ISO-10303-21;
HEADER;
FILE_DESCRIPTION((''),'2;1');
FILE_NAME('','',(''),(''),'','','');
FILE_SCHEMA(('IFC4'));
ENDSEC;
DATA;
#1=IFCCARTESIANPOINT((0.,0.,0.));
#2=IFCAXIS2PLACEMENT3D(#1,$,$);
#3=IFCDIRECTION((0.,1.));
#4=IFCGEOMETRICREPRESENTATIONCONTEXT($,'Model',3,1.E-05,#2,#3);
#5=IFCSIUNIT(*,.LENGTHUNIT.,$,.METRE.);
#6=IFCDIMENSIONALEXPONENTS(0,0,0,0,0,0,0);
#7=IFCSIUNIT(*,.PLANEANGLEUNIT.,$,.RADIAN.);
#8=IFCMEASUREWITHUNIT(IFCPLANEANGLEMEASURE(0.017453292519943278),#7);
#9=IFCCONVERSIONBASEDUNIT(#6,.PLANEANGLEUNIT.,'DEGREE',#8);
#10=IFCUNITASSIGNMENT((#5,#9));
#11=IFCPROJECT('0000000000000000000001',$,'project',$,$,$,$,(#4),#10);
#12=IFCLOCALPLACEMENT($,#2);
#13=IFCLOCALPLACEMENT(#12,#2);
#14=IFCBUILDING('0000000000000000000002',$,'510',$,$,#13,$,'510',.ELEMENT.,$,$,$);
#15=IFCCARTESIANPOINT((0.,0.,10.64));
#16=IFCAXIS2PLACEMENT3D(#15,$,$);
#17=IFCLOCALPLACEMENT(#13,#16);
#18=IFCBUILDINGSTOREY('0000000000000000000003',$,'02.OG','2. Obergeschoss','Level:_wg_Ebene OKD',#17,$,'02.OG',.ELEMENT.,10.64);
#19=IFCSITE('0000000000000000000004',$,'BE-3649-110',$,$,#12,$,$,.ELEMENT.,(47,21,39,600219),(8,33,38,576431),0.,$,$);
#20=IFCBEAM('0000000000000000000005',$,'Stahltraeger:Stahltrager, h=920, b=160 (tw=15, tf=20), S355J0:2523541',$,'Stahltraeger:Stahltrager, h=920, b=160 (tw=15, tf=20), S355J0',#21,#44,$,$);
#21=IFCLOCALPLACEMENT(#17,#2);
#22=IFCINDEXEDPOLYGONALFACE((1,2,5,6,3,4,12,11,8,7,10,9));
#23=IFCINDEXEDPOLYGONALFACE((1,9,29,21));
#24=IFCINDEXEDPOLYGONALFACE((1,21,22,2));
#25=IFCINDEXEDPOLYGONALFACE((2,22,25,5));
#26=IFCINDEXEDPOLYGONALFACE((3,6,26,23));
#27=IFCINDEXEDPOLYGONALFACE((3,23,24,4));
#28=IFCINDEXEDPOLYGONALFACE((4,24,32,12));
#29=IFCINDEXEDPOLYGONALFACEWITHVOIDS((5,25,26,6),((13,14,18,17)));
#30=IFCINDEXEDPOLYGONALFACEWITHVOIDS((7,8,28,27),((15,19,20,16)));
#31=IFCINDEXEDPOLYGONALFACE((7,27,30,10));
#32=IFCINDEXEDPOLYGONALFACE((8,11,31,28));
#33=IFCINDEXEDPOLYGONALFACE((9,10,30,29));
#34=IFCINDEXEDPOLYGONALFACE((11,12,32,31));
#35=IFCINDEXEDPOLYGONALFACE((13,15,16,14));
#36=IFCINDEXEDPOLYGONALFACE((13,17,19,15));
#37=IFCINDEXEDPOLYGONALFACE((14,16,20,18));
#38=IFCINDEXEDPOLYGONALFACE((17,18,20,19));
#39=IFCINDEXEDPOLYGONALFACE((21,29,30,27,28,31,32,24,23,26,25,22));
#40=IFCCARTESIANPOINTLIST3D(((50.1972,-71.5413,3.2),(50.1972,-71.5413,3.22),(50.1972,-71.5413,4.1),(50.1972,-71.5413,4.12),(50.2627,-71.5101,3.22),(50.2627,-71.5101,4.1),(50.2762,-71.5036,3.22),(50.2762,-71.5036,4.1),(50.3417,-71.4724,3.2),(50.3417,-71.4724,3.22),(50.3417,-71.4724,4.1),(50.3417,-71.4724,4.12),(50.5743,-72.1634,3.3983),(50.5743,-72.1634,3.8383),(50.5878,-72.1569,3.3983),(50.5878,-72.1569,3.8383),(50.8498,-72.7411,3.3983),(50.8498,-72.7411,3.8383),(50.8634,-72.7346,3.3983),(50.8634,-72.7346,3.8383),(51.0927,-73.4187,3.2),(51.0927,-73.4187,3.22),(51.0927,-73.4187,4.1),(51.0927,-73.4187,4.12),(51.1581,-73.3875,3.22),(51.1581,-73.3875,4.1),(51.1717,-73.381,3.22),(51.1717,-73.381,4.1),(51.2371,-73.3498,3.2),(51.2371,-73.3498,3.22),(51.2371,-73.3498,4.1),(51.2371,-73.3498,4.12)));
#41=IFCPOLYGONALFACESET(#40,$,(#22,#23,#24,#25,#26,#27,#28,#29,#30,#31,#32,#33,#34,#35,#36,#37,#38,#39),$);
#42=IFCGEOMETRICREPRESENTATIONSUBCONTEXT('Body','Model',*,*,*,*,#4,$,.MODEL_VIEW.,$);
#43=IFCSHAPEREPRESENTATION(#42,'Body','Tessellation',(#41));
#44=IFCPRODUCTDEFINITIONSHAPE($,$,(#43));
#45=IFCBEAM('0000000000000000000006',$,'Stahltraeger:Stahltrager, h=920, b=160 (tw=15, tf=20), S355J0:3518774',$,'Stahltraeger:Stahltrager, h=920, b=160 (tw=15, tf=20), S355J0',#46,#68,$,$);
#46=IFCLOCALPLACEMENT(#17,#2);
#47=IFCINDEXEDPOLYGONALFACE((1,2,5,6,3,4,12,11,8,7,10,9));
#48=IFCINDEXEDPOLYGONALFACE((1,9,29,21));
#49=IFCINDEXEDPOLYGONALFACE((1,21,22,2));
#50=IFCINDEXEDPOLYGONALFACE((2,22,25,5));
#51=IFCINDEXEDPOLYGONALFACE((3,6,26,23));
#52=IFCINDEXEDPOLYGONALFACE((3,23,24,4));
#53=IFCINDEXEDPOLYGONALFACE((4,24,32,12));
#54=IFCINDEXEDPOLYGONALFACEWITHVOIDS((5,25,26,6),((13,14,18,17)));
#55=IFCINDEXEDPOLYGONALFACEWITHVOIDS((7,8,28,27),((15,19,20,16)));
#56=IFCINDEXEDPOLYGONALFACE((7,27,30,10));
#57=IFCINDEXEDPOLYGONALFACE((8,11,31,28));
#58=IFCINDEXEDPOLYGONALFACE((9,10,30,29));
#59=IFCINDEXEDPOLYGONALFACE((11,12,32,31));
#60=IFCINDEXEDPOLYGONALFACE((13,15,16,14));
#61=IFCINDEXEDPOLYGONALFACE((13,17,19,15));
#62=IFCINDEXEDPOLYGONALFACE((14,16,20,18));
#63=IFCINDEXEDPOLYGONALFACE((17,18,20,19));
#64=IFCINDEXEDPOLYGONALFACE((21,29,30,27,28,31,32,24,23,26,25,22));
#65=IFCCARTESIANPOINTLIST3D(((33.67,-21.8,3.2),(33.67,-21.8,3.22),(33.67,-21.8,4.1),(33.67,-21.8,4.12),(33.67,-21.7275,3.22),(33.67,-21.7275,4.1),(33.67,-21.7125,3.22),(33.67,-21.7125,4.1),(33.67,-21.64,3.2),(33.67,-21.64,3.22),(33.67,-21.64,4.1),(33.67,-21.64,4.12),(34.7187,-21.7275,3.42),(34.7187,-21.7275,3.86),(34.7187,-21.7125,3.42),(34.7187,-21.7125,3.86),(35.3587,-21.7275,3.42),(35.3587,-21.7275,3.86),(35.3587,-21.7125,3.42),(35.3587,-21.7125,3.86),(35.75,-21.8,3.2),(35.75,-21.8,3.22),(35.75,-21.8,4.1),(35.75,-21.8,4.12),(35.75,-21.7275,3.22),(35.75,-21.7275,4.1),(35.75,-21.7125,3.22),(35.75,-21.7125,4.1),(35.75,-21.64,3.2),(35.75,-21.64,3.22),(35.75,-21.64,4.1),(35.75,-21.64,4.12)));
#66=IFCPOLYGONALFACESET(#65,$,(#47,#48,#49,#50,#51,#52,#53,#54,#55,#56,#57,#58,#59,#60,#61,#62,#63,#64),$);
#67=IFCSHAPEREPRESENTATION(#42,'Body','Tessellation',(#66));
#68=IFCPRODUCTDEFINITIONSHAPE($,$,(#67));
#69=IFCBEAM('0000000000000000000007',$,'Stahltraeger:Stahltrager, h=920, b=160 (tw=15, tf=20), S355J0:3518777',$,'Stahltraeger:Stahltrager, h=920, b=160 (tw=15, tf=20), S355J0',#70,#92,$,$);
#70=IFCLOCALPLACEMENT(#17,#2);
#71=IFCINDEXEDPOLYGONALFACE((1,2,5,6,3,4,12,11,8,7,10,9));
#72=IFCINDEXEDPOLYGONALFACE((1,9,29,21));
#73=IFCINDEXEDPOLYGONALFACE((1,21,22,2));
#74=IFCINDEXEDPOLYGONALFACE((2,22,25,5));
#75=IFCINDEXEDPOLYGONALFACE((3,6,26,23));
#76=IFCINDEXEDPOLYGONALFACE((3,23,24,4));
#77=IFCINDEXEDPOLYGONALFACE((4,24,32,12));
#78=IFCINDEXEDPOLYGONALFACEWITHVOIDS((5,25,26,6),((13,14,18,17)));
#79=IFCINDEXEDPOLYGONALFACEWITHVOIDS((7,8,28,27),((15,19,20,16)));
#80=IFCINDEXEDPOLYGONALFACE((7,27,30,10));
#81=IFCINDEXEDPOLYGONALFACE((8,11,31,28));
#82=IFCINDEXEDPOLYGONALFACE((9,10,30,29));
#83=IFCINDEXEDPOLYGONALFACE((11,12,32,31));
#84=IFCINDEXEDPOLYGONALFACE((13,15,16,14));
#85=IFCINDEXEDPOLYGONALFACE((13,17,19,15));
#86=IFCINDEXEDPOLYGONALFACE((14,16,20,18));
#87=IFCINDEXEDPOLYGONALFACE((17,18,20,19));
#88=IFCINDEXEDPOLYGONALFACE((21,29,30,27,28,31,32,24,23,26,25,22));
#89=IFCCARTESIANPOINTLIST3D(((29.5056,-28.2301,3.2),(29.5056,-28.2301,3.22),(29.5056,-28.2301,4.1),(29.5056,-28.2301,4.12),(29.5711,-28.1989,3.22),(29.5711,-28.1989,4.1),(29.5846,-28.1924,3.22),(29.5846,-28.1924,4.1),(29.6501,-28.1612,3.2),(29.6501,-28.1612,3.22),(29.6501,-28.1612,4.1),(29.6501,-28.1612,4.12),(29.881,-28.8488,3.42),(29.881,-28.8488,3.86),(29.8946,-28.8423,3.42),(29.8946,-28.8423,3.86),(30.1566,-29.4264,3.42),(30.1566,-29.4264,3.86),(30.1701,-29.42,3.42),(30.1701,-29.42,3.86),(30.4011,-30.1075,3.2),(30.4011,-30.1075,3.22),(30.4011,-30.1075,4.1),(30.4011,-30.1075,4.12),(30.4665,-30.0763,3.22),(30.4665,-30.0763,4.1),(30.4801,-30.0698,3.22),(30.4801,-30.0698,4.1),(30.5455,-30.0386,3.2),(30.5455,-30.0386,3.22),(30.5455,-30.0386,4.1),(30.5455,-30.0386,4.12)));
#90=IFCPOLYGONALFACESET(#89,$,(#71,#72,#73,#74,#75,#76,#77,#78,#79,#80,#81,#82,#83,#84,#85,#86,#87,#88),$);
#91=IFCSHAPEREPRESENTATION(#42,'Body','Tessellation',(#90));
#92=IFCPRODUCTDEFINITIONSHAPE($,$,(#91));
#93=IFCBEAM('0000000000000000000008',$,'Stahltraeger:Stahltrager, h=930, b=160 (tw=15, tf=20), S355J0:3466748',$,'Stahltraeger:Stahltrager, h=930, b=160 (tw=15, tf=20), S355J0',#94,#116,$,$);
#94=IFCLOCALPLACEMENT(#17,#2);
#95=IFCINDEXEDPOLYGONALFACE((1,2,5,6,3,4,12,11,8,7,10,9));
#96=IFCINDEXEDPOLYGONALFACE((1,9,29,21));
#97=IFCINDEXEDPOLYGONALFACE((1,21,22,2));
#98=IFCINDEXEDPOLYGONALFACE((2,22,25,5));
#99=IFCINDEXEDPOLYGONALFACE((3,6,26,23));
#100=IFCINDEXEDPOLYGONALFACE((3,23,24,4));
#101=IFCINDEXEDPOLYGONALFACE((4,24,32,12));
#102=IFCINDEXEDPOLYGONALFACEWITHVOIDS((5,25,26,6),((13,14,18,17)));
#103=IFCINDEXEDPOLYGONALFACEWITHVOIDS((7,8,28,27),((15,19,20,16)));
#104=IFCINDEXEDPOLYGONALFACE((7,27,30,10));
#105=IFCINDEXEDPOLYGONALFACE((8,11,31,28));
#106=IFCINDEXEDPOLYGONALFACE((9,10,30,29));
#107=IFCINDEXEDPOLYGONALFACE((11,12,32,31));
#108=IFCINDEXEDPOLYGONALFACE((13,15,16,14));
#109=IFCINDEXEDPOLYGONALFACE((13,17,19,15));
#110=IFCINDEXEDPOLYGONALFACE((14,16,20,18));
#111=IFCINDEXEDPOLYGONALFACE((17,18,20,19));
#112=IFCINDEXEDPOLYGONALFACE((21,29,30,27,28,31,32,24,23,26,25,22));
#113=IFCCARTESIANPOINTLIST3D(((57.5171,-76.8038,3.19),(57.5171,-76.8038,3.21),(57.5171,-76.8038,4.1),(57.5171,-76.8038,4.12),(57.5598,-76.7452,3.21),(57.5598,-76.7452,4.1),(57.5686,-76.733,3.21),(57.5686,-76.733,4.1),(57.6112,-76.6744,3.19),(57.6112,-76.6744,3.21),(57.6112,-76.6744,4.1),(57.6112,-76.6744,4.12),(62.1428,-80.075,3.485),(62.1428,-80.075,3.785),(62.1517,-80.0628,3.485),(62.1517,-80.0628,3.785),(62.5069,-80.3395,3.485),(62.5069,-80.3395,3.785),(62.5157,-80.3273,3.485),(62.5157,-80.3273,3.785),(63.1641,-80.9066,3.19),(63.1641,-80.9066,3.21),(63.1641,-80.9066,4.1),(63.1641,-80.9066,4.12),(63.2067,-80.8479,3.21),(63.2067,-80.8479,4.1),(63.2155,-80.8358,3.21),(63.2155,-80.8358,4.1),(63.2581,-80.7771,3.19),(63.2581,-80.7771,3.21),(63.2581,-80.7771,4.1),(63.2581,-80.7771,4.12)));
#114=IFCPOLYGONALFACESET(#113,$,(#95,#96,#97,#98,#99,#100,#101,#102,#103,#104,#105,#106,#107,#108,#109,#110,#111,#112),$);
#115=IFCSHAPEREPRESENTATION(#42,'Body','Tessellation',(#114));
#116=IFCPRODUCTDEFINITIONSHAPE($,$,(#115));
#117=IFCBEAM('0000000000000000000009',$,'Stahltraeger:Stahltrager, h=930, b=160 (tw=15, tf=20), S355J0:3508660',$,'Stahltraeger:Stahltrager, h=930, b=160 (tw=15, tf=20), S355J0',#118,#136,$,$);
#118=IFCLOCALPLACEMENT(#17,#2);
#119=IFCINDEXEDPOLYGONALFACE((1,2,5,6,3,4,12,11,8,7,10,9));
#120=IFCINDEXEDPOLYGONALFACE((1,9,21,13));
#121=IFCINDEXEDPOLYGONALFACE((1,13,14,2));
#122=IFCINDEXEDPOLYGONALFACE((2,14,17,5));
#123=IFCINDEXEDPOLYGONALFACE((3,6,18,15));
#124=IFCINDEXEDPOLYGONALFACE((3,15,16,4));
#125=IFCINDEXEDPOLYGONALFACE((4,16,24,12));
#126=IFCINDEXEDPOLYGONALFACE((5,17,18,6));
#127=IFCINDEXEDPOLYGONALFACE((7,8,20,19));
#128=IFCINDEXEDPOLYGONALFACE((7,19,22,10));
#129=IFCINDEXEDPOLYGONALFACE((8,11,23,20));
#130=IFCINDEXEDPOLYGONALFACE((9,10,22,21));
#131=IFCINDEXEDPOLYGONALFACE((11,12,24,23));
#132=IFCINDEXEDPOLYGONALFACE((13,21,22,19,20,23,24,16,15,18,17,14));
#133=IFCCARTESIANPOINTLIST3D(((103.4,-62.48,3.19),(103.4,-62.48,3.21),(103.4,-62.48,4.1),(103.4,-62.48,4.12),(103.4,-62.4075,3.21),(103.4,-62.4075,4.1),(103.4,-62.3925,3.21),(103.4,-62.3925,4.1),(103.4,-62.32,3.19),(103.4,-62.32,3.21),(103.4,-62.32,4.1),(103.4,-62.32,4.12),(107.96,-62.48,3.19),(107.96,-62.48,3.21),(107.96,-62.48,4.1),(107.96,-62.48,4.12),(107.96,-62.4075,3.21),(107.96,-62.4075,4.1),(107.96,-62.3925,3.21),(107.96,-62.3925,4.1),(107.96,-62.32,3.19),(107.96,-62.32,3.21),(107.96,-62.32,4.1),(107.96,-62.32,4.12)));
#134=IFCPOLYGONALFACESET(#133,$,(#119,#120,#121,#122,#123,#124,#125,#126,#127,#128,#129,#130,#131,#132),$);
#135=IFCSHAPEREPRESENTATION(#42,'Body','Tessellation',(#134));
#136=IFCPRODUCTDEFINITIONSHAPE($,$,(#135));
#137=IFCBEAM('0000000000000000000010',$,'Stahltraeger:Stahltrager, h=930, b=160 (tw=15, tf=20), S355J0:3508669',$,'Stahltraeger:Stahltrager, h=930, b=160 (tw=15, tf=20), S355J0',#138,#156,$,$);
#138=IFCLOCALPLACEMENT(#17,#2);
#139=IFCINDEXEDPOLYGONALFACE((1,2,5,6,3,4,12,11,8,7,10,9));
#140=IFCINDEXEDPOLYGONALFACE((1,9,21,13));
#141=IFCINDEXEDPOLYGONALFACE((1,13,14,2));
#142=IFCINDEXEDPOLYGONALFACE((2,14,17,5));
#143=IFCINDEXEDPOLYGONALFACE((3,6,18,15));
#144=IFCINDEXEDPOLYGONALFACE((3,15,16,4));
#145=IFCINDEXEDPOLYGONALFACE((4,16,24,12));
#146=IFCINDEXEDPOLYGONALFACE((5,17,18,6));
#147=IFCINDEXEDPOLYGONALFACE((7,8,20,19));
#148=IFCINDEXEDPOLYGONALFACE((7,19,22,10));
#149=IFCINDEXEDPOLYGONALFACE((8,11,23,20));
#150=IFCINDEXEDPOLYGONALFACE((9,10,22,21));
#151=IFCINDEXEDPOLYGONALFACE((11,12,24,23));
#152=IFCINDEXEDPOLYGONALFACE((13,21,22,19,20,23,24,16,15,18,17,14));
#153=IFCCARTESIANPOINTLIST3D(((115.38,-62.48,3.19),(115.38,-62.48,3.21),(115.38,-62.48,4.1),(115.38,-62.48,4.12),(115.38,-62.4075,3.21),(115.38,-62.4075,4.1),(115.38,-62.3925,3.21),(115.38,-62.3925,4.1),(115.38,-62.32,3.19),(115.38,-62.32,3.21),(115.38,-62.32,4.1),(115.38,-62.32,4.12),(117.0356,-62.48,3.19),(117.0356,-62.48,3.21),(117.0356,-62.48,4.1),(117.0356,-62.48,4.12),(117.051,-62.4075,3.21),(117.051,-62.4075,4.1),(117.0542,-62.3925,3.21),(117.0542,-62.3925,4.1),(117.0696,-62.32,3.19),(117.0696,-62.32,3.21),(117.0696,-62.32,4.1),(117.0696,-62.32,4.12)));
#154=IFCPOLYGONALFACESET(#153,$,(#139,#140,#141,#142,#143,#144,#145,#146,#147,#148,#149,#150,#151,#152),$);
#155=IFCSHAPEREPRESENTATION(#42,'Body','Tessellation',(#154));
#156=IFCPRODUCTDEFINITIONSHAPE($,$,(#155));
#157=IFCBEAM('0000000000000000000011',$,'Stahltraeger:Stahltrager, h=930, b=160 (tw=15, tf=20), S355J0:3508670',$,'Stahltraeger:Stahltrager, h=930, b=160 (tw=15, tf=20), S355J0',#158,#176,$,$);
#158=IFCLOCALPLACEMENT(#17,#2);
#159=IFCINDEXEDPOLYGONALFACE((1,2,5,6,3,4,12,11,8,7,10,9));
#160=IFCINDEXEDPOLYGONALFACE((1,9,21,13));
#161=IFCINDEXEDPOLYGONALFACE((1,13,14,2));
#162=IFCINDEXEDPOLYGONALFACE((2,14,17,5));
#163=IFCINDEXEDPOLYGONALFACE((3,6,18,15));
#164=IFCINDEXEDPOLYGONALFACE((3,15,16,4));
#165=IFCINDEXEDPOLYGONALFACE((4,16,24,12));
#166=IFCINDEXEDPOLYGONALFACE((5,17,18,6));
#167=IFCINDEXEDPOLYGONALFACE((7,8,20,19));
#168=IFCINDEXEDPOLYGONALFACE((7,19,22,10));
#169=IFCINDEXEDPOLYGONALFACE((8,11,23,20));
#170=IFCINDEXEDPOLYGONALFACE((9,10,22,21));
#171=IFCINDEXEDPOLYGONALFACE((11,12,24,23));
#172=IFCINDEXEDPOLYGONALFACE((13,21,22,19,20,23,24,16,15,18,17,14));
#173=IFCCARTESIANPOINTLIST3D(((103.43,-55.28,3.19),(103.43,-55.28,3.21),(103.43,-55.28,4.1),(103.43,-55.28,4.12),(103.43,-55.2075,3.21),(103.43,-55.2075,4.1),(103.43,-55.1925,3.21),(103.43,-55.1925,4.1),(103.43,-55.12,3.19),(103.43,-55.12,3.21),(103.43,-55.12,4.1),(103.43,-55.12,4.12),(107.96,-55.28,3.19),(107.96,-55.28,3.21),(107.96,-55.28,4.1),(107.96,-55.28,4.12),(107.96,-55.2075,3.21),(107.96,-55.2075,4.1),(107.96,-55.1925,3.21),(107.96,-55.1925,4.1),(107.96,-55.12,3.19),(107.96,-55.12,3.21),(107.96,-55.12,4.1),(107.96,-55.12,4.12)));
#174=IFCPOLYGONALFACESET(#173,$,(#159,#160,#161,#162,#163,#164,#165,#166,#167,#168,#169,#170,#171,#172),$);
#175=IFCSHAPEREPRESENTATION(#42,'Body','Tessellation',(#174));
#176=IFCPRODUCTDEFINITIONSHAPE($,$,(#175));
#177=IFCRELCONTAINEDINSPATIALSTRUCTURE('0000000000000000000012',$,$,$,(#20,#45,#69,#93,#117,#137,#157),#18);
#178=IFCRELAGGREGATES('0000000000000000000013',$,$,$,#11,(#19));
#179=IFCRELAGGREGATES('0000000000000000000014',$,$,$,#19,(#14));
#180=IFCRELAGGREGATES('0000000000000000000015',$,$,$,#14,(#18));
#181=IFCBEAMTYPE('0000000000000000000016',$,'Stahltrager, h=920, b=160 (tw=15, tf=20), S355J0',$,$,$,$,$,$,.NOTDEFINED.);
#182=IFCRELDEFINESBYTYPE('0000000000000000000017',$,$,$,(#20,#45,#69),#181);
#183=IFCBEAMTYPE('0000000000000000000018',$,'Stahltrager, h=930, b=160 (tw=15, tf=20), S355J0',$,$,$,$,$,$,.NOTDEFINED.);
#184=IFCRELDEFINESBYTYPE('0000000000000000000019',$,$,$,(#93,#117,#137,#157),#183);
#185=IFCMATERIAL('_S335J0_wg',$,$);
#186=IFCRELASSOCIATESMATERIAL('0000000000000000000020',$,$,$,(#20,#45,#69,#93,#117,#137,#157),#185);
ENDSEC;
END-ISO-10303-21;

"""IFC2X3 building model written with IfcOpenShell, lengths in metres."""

from ifc_helpers import new_model, entity, si_unit, converted_unit, direction, frame, frame_2d, origin, place, context, subcontext, project, spatial, polyline, rectangle, i_section, outline, extrude, boolean, clip, halfspace, material, type_object, element, save


model = new_model("IFC2X3")

# Units and contexts
model_context = context("Model", 3, precision=1e-05, world=origin(), true_north=direction((0.0, 1.0)))
body_context = subcontext(model_context, "Body", "Model", "MODEL_VIEW")
ifc_project = project(units=[si_unit("LENGTHUNIT", "METRE"), converted_unit("PLANEANGLEUNIT", "DEGREE", entity("IfcPlaneAngleMeasure", 0.017453292519943278), si_unit("PLANEANGLEUNIT", "RADIAN"), dimensions=[0, 0, 0, 0, 0, 0, 0])], contexts=[model_context])

# Site, building, storey
site_placement = place(None, origin())
site = spatial("IfcSite", under=ifc_project, at=site_placement, Name="BE-3649-110", CompositionType="ELEMENT", RefLatitude=(47, 21, 39, 600219), RefLongitude=(8, 33, 38, 576431), RefElevation=0.0)
building_placement = place(site_placement, origin())
building = spatial("IfcBuilding", under=site, at=building_placement, Name="510", LongName="510", CompositionType="ELEMENT")
storey_placement = place(building_placement, frame((0.0, 0.0, 10.64)))
storey = spatial("IfcBuildingStorey", under=building, at=storey_placement, Name="02.OG", Description="2. Obergeschoss", ObjectType="Level:_wg_Ebene OKD", LongName="02.OG", CompositionType="ELEMENT", Elevation=10.64)

# Beams
ifc_material_1 = material(Name="_S335J0_wg")
beam_type_1 = type_object("IfcBeamType", Name="Stahltrager, h=920, b=160 (tw=15, tf=20), S355J0", PredefinedType="NOTDEFINED")
beam_1_placement = place(storey_placement, frame((50.2695, -71.5068, 4.12), z_axis=(0.0, 0.0, 1.0), x_axis=(0.430511, -0.902585, 0.0)))
element("IfcBeam", 1, at=beam_1_placement, inside=storey, type_object=beam_type_1, material=ifc_material_1, Name="Stahltraeger:Stahltrager, h=920, b=160 (tw=15, tf=20), S355J0:2523541", ObjectType="Stahltraeger:Stahltrager, h=920, b=160 (tw=15, tf=20), S355J0", context=body_context, shape_type="SweptSolid", body=[
    boolean("DIFFERENCE", extrude(i_section(OverallWidth=0.16, OverallDepth=0.92, WebThickness=0.015, FlangeThickness=0.02, at=frame_2d((0.0, 0.0), x_axis=(0.0, 1.0))), frame((0.0, 0.0, -0.46), z_axis=(1.0, 0.0, 0.0), x_axis=(0.0, 0.0, -1.0)), (0.0, 0.0, 1.0), 2.08), extrude(rectangle(XDim=0.44, YDim=0.64, at=frame_2d((0.0, 0.0), x_axis=(0.0, 1.0))), frame((1.0438, 0.0075, -0.5017), z_axis=(0.0, -1.0, 0.0), x_axis=(-1.0, 0.0, 0.0)), (0.0, 0.0, 1.0), 0.015)),
])
beam_2_placement = place(storey_placement, frame((33.67, -21.72, 4.12)))
element("IfcBeam", 2, at=beam_2_placement, inside=storey, type_object=beam_type_1, material=ifc_material_1, Name="Stahltraeger:Stahltrager, h=920, b=160 (tw=15, tf=20), S355J0:3518774", ObjectType="Stahltraeger:Stahltrager, h=920, b=160 (tw=15, tf=20), S355J0", context=body_context, shape_type="SweptSolid", body=[
    boolean("DIFFERENCE", extrude(i_section(OverallWidth=0.16, OverallDepth=0.92, WebThickness=0.015, FlangeThickness=0.02, at=frame_2d((0.0, 0.0), x_axis=(0.0, 1.0))), frame((0.0, 0.0, -0.46), z_axis=(1.0, 0.0, 0.0), x_axis=(0.0, 0.0, -1.0)), (0.0, 0.0, 1.0), 2.08), extrude(rectangle(XDim=0.44, YDim=0.64, at=frame_2d((0.0, 0.0), x_axis=(0.0, 1.0))), frame((1.3687, 0.0075, -0.48), z_axis=(0.0, -1.0, 0.0), x_axis=(-1.0, 0.0, 0.0)), (0.0, 0.0, 1.0), 0.015)),
])
beam_3_placement = place(storey_placement, frame((30.4733, -30.073, 4.12), z_axis=(0.0, 0.0, 1.0), x_axis=(-0.430511, 0.902585, 0.0)))
element("IfcBeam", 3, at=beam_3_placement, inside=storey, type_object=beam_type_1, material=ifc_material_1, Name="Stahltraeger:Stahltrager, h=920, b=160 (tw=15, tf=20), S355J0:3518777", ObjectType="Stahltraeger:Stahltrager, h=920, b=160 (tw=15, tf=20), S355J0", context=body_context, shape_type="SweptSolid", body=[
    boolean("DIFFERENCE", extrude(i_section(OverallWidth=0.16, OverallDepth=0.92, WebThickness=0.015, FlangeThickness=0.02, at=frame_2d((0.0, 0.0), x_axis=(0.0, 1.0))), frame((0.0, 0.0, -0.46), z_axis=(1.0, 0.0, 0.0), x_axis=(0.0, 0.0, -1.0)), (0.0, 0.0, 1.0), 2.08), extrude(rectangle(XDim=0.44, YDim=0.64, at=frame_2d((0.0, 0.0), x_axis=(0.0, 1.0))), frame((1.04, 0.0075, -0.48), z_axis=(0.0, -1.0, 0.0), x_axis=(-1.0, 0.0, 0.0)), (0.0, 0.0, 1.0), 0.015)),
])
beam_type_2 = type_object("IfcBeamType", Name="Stahltrager, h=930, b=160 (tw=15, tf=20), S355J0", PredefinedType="NOTDEFINED")
beam_4_placement = place(storey_placement, frame((57.5642, -76.7391, 4.12), z_axis=(0.0, 0.0, 1.0), x_axis=(0.809017, -0.587785, 0.0)))
element("IfcBeam", 4, at=beam_4_placement, inside=storey, type_object=beam_type_2, material=ifc_material_1, Name="Stahltraeger:Stahltrager, h=930, b=160 (tw=15, tf=20), S355J0:3466748", ObjectType="Stahltraeger:Stahltrager, h=930, b=160 (tw=15, tf=20), S355J0", context=body_context, shape_type="SweptSolid", body=[
    boolean("DIFFERENCE", extrude(i_section(OverallWidth=0.16, OverallDepth=0.93, WebThickness=0.015, FlangeThickness=0.02, at=frame_2d((0.0, 0.0), x_axis=(0.0, 1.0))), frame((0.0, 0.0, -0.465), z_axis=(1.0, 0.0, 0.0), x_axis=(0.0, 0.0, -1.0)), (0.0, 0.0, 1.0), 6.98), extrude(rectangle(XDim=0.3, YDim=0.45, at=frame_2d((0.0, 0.0), x_axis=(0.0, 1.0))), frame((5.89, -0.0075, -0.485), z_axis=(0.0, 1.0, 0.0), x_axis=(1.0, 0.0, 0.0)), (0.0, 0.0, 1.0), 0.015)),
])
beam_5_placement = place(storey_placement, frame((103.4, -62.48, 3.19)))
element("IfcBeam", 5, at=beam_5_placement, inside=storey, type_object=beam_type_2, material=ifc_material_1, Name="Stahltraeger:Stahltrager, h=930, b=160 (tw=15, tf=20), S355J0:3508660", ObjectType="Stahltraeger:Stahltrager, h=930, b=160 (tw=15, tf=20), S355J0", context=body_context, shape_type="SweptSolid", body=[
    extrude(outline(polyline([(-0.08, -0.445), (-0.08, -0.465), (0.08, -0.465), (0.08, -0.445), (0.0075, -0.445), (0.0075, 0.445), (0.08, 0.445), (0.08, 0.465), (-0.08, 0.465), (-0.08, 0.445), (-0.0075, 0.445), (-0.0075, -0.445), (-0.08, -0.445)])), frame((0.0, 0.08, 0.465), z_axis=(-1.0, 0.0, 0.0), x_axis=(0.0, -1.0, 0.0)), (0.0, 0.0, -1.0), 4.56),
])
beam_6_placement = place(storey_placement, frame((115.38, -62.4, 4.12)))
element("IfcBeam", 6, at=beam_6_placement, inside=storey, type_object=beam_type_2, material=ifc_material_1, Name="Stahltraeger:Stahltrager, h=930, b=160 (tw=15, tf=20), S355J0:3508669", ObjectType="Stahltraeger:Stahltrager, h=930, b=160 (tw=15, tf=20), S355J0", context=body_context, shape_type="SweptSolid", body=[
    clip(extrude(i_section(OverallWidth=0.16, OverallDepth=0.93, WebThickness=0.015, FlangeThickness=0.02, at=frame_2d((0.0, 0.0), x_axis=(0.0, 1.0))), frame((0.0, 0.0, -0.465), z_axis=(1.0, 0.0, 0.0), x_axis=(0.0, 0.0, -1.0)), (0.0, 0.0, 1.0), 1.6896), halfspace(frame((1.5961, -0.3601, 10.02), z_axis=(0.978148, -0.207912, 0.0), x_axis=(0.207912, 0.978148, 0.0)), False)),
])
beam_7_placement = place(storey_placement, frame((103.43, -55.28, 3.19)))
element("IfcBeam", 7, at=beam_7_placement, inside=storey, type_object=beam_type_2, material=ifc_material_1, Name="Stahltraeger:Stahltrager, h=930, b=160 (tw=15, tf=20), S355J0:3508670", ObjectType="Stahltraeger:Stahltrager, h=930, b=160 (tw=15, tf=20), S355J0", context=body_context, shape_type="SweptSolid", body=[
    extrude(outline(polyline([(-0.08, -0.445), (-0.08, -0.465), (0.08, -0.465), (0.08, -0.445), (0.0075, -0.445), (0.0075, 0.445), (0.08, 0.445), (0.08, 0.465), (-0.08, 0.465), (-0.08, 0.445), (-0.0075, 0.445), (-0.0075, -0.445), (-0.08, -0.445)])), frame((0.0, 0.08, 0.465), z_axis=(-1.0, 0.0, 0.0), x_axis=(0.0, -1.0, 0.0)), (0.0, 0.0, -1.0), 4.53),
])

save(model, "model.ifc")
